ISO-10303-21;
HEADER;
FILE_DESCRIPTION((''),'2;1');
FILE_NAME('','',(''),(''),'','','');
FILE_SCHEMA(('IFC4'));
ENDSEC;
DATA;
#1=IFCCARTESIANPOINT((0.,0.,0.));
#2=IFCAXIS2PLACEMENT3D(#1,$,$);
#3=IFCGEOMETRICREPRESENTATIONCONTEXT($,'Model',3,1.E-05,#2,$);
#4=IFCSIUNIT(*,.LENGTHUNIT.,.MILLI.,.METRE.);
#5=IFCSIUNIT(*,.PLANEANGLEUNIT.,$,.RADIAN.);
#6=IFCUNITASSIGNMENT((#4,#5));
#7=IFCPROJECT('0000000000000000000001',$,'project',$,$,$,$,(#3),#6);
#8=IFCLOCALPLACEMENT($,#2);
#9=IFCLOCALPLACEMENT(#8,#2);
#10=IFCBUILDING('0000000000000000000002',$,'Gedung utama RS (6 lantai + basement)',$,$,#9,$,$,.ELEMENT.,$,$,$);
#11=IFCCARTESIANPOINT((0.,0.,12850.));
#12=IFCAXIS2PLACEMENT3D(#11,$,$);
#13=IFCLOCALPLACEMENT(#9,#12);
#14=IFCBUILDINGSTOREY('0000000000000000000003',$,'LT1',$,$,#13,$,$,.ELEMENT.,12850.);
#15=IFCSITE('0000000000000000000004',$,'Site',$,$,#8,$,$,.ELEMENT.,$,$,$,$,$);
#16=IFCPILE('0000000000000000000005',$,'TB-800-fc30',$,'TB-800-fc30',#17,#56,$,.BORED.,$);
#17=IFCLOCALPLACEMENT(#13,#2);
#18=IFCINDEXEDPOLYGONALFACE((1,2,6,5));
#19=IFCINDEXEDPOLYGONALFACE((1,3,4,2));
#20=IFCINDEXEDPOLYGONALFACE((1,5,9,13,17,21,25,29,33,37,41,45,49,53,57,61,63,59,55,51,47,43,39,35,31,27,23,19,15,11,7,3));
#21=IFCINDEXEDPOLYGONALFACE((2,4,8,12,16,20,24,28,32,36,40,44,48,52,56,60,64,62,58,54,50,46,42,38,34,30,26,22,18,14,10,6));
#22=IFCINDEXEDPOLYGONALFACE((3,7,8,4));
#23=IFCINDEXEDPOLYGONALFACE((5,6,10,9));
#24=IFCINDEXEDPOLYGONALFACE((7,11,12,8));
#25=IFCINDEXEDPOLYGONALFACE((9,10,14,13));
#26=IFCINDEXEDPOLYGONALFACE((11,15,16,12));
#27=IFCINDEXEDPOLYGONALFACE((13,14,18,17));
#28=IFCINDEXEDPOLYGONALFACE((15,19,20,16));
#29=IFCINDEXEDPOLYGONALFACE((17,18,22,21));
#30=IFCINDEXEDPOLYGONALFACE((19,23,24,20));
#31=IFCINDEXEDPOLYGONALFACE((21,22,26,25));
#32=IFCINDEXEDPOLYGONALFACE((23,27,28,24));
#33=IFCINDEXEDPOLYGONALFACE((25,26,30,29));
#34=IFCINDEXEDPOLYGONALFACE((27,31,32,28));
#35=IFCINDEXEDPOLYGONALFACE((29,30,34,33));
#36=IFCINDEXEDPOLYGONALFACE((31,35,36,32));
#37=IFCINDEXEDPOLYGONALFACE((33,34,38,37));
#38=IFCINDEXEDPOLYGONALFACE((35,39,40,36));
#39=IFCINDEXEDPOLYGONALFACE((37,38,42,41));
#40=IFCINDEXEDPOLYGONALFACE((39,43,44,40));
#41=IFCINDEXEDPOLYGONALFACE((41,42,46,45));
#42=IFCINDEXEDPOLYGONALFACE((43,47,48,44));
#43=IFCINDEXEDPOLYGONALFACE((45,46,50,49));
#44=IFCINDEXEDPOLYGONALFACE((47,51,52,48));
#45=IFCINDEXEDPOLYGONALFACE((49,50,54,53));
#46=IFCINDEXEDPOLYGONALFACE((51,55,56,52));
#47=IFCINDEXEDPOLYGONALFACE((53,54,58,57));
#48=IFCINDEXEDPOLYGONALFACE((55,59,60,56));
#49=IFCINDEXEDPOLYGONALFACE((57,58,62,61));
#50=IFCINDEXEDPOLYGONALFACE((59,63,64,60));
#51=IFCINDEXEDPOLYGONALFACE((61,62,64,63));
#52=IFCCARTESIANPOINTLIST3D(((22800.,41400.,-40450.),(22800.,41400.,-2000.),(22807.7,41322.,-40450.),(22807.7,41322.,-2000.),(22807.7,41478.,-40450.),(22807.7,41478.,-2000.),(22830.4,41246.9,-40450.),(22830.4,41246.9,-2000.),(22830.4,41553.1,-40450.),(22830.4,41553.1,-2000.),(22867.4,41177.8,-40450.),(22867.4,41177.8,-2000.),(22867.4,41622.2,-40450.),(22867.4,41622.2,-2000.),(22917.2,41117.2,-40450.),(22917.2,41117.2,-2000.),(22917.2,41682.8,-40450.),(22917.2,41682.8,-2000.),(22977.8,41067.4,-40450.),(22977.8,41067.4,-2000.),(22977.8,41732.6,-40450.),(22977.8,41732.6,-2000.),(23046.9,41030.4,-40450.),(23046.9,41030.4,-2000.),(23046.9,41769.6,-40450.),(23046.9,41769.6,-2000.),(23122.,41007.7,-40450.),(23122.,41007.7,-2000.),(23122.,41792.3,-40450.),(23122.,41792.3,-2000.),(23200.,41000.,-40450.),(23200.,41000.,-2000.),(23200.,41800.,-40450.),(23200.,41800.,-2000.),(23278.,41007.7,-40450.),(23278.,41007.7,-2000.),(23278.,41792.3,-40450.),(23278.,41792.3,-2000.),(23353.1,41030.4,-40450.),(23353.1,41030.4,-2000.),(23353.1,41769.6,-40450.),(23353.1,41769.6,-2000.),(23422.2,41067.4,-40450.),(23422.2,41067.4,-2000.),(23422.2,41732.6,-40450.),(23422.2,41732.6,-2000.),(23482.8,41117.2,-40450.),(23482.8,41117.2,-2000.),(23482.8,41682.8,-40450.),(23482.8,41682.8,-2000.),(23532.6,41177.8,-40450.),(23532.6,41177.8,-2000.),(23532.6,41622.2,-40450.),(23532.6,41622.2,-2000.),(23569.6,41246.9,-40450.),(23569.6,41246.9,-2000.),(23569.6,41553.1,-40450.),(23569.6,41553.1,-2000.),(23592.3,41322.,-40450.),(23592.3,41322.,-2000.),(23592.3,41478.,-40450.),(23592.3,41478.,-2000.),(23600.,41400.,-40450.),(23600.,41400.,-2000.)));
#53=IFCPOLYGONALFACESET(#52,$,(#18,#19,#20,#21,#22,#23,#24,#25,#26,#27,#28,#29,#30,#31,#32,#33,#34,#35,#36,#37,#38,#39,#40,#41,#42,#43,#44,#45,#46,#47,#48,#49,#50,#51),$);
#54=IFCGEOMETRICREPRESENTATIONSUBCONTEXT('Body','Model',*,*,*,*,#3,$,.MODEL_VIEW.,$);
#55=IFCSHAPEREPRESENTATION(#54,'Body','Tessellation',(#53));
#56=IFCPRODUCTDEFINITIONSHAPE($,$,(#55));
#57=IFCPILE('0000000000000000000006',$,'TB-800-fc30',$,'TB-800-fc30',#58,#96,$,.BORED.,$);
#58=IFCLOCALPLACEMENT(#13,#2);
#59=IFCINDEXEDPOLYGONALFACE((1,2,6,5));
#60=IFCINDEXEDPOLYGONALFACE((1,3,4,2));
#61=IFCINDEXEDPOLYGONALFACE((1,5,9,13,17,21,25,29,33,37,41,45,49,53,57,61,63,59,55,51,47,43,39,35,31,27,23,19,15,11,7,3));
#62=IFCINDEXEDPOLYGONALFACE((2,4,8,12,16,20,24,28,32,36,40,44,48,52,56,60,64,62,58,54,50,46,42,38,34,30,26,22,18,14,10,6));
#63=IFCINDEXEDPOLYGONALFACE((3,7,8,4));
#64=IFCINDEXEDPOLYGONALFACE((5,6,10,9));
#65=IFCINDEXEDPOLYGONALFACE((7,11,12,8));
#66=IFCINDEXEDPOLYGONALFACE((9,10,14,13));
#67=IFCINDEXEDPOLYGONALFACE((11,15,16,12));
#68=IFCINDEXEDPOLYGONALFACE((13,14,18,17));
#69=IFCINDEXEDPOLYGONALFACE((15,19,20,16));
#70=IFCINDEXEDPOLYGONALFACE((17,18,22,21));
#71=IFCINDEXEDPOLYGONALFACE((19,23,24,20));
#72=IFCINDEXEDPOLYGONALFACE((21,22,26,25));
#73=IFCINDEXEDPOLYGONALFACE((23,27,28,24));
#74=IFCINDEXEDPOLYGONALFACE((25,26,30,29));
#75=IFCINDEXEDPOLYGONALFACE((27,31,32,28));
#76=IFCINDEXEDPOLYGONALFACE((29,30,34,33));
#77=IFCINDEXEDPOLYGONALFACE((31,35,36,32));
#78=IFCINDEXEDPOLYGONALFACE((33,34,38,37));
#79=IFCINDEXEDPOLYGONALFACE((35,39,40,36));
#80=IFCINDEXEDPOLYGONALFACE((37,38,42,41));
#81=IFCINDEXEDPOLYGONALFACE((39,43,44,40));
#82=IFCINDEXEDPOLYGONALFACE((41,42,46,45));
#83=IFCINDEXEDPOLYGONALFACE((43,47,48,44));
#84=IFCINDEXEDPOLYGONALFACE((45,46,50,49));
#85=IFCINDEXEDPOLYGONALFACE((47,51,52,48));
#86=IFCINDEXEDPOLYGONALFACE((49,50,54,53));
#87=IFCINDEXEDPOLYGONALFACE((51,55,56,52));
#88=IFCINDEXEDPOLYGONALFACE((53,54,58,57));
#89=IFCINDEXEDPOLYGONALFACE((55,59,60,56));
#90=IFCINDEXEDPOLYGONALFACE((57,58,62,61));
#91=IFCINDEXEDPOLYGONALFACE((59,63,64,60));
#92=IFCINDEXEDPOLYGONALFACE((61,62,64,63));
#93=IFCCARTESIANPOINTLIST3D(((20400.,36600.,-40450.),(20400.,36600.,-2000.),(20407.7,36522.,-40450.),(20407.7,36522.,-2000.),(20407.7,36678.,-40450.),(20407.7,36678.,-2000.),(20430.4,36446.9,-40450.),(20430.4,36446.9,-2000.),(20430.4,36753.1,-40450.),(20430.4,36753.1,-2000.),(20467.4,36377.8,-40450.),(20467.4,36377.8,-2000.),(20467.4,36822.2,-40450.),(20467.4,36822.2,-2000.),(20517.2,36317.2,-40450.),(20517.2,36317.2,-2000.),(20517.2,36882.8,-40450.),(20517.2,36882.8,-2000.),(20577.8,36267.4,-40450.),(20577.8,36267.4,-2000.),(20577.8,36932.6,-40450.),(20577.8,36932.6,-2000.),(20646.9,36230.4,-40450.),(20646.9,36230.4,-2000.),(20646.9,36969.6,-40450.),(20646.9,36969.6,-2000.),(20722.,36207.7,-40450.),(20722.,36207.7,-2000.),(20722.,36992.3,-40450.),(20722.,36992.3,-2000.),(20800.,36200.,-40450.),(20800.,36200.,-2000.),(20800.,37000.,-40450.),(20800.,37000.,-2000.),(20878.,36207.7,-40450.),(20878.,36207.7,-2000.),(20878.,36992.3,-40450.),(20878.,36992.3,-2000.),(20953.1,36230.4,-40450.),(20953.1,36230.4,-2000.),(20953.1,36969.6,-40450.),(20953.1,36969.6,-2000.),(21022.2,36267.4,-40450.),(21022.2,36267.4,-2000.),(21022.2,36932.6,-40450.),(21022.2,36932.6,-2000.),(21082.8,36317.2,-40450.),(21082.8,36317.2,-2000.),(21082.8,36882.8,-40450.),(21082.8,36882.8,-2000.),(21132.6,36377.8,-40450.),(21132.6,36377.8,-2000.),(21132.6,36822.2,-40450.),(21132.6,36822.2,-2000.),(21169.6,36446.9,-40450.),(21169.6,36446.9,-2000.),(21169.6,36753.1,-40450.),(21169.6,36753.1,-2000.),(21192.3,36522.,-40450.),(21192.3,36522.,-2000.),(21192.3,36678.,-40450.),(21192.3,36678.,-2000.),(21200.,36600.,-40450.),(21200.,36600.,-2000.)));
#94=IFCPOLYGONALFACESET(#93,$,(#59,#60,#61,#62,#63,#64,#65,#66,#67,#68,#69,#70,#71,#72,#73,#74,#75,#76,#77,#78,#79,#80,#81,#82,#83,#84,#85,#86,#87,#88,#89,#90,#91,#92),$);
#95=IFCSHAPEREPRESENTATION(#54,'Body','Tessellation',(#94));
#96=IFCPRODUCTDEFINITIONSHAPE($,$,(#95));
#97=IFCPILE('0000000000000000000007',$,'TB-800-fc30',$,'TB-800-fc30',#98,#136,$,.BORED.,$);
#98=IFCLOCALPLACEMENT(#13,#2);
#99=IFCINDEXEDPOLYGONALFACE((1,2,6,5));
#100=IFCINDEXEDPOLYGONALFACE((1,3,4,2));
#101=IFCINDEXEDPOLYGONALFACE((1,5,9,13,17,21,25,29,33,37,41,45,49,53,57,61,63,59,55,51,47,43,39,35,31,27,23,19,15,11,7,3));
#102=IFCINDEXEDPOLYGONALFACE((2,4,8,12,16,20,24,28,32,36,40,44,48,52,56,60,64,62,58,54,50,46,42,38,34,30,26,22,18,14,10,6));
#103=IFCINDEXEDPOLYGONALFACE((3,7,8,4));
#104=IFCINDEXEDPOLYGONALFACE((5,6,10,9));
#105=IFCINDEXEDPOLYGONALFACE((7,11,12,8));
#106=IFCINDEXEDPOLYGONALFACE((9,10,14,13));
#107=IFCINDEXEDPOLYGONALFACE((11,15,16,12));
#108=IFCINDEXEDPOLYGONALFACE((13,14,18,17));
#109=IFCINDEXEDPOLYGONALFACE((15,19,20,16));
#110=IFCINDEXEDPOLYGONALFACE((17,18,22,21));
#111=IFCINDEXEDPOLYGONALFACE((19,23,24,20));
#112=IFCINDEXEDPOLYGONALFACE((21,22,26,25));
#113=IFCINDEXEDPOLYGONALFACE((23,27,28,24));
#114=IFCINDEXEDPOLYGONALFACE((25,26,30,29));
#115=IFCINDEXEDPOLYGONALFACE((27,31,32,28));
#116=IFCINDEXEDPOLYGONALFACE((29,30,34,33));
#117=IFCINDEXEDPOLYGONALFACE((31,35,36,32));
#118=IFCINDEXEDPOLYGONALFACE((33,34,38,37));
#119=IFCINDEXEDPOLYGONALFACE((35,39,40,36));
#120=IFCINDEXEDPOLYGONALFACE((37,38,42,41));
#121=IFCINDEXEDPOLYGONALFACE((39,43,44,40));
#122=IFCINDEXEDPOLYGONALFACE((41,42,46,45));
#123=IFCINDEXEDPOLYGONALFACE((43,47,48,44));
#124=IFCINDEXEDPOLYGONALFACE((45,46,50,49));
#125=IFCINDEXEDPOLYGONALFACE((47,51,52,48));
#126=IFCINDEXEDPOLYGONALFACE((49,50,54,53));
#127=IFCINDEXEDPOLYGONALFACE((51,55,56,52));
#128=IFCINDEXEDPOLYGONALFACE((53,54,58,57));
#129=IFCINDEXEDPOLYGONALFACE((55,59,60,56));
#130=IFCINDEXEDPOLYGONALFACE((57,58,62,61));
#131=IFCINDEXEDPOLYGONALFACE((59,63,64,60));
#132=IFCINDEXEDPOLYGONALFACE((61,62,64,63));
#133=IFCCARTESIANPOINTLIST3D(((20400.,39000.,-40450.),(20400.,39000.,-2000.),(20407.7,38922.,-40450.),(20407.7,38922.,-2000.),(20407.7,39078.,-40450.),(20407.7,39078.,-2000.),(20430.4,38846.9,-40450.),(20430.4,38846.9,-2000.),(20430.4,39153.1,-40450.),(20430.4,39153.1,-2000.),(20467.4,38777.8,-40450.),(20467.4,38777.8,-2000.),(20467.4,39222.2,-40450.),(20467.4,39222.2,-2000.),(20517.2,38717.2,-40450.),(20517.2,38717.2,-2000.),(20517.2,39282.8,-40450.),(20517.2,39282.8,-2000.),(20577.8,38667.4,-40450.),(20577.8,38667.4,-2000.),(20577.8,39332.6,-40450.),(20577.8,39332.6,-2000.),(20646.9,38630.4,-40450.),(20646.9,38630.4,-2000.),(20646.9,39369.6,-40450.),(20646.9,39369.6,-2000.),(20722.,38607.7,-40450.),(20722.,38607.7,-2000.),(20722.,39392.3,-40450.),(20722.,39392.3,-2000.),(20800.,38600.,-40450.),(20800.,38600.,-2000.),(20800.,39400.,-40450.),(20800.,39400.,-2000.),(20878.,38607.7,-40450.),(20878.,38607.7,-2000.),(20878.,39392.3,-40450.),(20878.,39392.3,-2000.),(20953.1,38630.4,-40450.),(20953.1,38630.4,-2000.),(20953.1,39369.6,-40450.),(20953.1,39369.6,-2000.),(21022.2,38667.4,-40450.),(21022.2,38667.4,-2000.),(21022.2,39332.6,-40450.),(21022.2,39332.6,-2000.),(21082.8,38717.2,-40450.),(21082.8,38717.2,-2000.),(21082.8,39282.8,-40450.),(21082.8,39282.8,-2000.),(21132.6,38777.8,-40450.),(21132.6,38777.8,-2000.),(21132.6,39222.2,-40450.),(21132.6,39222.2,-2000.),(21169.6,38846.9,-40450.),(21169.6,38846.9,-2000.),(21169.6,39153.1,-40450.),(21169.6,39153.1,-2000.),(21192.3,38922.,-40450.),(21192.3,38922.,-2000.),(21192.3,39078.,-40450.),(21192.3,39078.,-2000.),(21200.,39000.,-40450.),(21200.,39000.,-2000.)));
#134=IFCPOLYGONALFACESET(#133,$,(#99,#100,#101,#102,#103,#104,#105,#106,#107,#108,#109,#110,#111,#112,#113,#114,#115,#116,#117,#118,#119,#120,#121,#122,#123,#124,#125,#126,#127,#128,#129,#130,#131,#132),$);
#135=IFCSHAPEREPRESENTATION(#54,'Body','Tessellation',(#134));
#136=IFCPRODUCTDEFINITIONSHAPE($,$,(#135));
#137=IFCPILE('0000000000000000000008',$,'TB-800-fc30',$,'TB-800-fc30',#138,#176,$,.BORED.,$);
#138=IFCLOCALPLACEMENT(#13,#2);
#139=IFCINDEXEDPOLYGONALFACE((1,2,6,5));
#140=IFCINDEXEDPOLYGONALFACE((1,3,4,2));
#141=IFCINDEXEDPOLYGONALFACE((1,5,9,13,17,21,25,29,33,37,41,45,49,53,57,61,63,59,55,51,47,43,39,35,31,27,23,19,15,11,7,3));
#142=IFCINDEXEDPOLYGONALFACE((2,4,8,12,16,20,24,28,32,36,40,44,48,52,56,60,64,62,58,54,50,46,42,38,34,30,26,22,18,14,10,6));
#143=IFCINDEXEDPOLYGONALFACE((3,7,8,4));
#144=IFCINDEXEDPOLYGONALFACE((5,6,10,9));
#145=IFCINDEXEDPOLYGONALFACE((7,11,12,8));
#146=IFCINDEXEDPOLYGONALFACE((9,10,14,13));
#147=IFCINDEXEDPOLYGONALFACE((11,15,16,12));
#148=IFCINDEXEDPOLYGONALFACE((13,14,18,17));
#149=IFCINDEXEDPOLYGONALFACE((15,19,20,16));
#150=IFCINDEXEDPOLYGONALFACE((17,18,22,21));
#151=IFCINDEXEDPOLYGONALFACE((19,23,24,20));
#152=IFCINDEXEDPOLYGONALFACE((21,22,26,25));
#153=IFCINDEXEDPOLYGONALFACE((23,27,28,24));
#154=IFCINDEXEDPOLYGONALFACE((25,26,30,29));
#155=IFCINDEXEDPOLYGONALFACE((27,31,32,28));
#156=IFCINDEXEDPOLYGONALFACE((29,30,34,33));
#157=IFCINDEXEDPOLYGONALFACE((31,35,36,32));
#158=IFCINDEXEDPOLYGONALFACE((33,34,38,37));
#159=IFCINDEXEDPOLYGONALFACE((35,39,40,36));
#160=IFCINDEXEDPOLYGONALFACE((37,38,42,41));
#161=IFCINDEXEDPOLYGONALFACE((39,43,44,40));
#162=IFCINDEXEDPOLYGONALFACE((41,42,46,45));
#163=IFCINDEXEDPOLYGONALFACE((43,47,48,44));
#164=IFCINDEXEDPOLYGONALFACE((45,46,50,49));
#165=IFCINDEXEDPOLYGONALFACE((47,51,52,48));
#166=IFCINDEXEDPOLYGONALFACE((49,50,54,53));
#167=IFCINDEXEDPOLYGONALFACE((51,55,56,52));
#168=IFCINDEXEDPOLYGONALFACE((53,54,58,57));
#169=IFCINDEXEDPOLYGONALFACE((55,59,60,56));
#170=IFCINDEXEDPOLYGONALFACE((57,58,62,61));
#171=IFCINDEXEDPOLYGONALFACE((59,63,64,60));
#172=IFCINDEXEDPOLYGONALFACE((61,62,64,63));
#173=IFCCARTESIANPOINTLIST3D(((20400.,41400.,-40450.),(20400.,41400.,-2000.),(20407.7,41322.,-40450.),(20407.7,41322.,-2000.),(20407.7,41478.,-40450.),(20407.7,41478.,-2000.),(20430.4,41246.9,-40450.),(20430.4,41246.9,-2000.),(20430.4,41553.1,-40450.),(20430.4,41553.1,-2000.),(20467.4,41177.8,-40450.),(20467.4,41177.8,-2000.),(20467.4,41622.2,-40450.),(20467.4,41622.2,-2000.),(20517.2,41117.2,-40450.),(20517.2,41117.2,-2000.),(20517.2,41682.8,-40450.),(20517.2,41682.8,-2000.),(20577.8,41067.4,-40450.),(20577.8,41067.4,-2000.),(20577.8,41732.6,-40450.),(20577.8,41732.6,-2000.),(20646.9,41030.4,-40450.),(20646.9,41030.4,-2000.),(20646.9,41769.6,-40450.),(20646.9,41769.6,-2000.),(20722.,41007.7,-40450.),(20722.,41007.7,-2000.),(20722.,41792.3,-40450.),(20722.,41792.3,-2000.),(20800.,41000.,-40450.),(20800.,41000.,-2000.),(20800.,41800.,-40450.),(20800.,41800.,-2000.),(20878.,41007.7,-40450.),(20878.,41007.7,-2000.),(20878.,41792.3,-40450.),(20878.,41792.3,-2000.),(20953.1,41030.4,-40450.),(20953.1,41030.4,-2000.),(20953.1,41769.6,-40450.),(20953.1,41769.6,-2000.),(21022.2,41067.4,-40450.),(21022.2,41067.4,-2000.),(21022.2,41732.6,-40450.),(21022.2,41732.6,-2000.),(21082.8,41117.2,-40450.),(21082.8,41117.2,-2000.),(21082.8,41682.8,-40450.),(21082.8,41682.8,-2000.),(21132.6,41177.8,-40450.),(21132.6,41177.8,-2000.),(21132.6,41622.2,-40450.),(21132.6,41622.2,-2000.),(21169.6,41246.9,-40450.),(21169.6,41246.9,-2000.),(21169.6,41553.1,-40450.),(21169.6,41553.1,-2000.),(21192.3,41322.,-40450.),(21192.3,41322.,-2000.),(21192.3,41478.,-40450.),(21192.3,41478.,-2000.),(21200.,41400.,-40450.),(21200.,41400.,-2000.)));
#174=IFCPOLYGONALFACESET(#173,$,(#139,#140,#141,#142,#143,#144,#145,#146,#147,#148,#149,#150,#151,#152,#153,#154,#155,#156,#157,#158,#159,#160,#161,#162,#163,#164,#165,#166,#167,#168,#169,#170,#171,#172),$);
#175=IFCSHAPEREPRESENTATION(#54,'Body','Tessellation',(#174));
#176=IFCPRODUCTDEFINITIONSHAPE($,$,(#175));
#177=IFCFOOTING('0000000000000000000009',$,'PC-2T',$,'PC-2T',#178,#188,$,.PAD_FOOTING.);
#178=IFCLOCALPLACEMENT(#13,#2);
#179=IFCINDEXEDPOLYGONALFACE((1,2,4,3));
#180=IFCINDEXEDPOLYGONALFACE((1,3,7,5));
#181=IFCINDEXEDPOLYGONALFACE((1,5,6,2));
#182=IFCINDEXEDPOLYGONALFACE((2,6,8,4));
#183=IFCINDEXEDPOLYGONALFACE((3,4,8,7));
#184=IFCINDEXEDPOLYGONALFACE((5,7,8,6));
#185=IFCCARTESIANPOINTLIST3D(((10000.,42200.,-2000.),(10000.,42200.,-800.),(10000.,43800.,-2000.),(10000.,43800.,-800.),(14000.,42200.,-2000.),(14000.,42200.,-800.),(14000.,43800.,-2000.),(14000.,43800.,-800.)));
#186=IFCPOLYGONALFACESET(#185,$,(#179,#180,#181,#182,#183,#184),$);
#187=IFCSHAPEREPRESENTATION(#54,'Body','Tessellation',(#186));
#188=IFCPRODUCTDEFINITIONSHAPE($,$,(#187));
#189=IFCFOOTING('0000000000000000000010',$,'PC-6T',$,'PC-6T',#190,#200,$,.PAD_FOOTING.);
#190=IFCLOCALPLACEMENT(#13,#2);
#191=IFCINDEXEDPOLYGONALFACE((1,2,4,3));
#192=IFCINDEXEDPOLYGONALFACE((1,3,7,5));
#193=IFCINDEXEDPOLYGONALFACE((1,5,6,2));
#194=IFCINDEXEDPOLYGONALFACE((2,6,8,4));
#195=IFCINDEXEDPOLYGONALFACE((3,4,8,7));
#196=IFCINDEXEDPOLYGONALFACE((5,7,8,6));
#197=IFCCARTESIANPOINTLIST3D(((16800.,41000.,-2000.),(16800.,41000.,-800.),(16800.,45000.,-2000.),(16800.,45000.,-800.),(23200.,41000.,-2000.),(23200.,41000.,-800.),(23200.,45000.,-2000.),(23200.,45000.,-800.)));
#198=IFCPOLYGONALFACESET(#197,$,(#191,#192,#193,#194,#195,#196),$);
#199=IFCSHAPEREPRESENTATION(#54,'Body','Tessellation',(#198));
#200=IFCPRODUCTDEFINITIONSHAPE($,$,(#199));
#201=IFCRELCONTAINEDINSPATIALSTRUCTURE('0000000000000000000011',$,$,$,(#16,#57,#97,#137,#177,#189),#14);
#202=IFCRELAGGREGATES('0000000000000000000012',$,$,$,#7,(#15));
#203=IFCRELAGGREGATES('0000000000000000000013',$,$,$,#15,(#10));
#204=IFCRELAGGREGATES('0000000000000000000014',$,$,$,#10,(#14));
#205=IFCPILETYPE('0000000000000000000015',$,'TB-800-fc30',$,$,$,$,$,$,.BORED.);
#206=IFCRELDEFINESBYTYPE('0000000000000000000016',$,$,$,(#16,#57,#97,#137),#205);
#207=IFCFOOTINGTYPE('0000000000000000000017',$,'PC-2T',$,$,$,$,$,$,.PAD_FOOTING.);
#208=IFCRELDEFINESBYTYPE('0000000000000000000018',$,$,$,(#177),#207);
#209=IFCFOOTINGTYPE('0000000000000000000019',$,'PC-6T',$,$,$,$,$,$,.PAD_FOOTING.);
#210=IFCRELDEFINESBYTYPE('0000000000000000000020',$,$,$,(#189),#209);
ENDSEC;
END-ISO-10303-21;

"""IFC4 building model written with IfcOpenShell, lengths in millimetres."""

from ifc_helpers import new_model, si_unit, frame, origin, origin_2d, place, context, subcontext, project, spatial, rectangle, circle, extrude, material_profile, profile_set, profile_usage, type_object, element, save


model = new_model("IFC4")

# Units and contexts
model_context = context("Model", 3, precision=1e-05, world=origin())
body_context = subcontext(model_context, "Body", "Model", "MODEL_VIEW")
ifc_project = project(units=[si_unit("LENGTHUNIT", "METRE", prefix="MILLI"), si_unit("PLANEANGLEUNIT", "RADIAN")], contexts=[model_context])

# Site, building, storey
site_placement = place(None, origin())
site = spatial("IfcSite", under=ifc_project, at=site_placement, Name="Site", CompositionType="ELEMENT")
building_placement = place(site_placement, origin())
building = spatial("IfcBuilding", under=site, at=building_placement, Name="Gedung utama RS (6 lantai + basement)", CompositionType="ELEMENT")
storey_placement = place(building_placement, frame((0.0, 0.0, 12850.0)))
storey = spatial("IfcBuildingStorey", under=building, at=storey_placement, Name="LT1", CompositionType="ELEMENT", Elevation=12850.0)

# Piles
ifc_material_profile_1 = material_profile(None, circle(Radius=400.0, at=origin_2d()), Name="TB-800-fc30")
ifc_profile_set_1 = profile_set([ifc_material_profile_1], Name="TB-800-fc30")
ifc_profile_usage_1 = profile_usage(ifc_profile_set_1, cardinal=5)
pile_type = type_object("IfcPileType", Name="TB-800-fc30", PredefinedType="BORED", material=ifc_profile_set_1)
for number, where, z_axis, x_axis, name in (
    (1, (23200.0, 41400.0, -40450.0), (0.0, 0.0, 1.0), (1.0, 0.0, 0.0), "TB-800-fc30"),
    (2, (20800.0, 36600.0, -40450.0), (0.0, 0.0, 1.0), (1.0, 0.0, 0.0), "TB-800-fc30"),
    (3, (20800.0, 39000.0, -40450.0), (0.0, 0.0, 1.0), (1.0, 0.0, 0.0), "TB-800-fc30"),
    (4, (20800.0, 41400.0, -40450.0), (0.0, 0.0, 1.0), (1.0, 0.0, 0.0), "TB-800-fc30"),
):
    element("IfcPile", number, at=place(storey_placement, frame(where, z_axis=z_axis, x_axis=x_axis)), inside=storey, type_object=pile_type, material=ifc_profile_usage_1, Name=name, ObjectType="TB-800-fc30", PredefinedType="BORED", context=body_context, shape_type="SweptSolid", body=[
        extrude(circle(Radius=400.0, at=origin_2d()), origin(), (0.0, 0.0, 1.0), 38450.0),
    ])

# Footings
ifc_material_profile_2 = material_profile(None, rectangle(XDim=4000.0, YDim=1600.0, at=origin_2d()), Name="PC-2T")
ifc_profile_set_2 = profile_set([ifc_material_profile_2], Name="PC-2T")
ifc_profile_usage_2 = profile_usage(ifc_profile_set_2, cardinal=5)
footing_type_1 = type_object("IfcFootingType", Name="PC-2T", PredefinedType="PAD_FOOTING", material=ifc_profile_set_2)
footing_placement = place(storey_placement, frame((12000.0, 43000.0, -2000.0), z_axis=(0.0, 0.0, 1.0), x_axis=(1.0, 0.0, 0.0)))
element("IfcFooting", 5, at=footing_placement, inside=storey, type_object=footing_type_1, material=ifc_profile_usage_2, Name="PC-2T", ObjectType="PC-2T", PredefinedType="PAD_FOOTING", context=body_context, shape_type="SweptSolid", body=[
    extrude(rectangle(XDim=4000.0, YDim=1600.0, at=origin_2d()), origin(), (0.0, 0.0, 1.0), 1200.0),
])
ifc_material_profile_3 = material_profile(None, rectangle(XDim=6400.0, YDim=4000.0, at=origin_2d()), Name="PC-6T")
ifc_profile_set_3 = profile_set([ifc_material_profile_3], Name="PC-6T")
ifc_profile_usage_3 = profile_usage(ifc_profile_set_3, cardinal=5)
footing_type_2 = type_object("IfcFootingType", Name="PC-6T", PredefinedType="PAD_FOOTING", material=ifc_profile_set_3)
for number, where, z_axis, x_axis, name in (
    (6, (20000.0, 43000.0, -2000.0), (0.0, 0.0, 1.0), (1.0, 0.0, 0.0), "PC-6T"),
):
    element("IfcFooting", number, at=place(storey_placement, frame(where, z_axis=z_axis, x_axis=x_axis)), inside=storey, type_object=footing_type_2, material=ifc_profile_usage_3, Name=name, ObjectType="PC-6T", PredefinedType="PAD_FOOTING", context=body_context, shape_type="SweptSolid", body=[
        extrude(rectangle(XDim=6400.0, YDim=4000.0, at=origin_2d()), origin(), (0.0, 0.0, 1.0), 1200.0),
    ])

save(model, "model.ifc")
